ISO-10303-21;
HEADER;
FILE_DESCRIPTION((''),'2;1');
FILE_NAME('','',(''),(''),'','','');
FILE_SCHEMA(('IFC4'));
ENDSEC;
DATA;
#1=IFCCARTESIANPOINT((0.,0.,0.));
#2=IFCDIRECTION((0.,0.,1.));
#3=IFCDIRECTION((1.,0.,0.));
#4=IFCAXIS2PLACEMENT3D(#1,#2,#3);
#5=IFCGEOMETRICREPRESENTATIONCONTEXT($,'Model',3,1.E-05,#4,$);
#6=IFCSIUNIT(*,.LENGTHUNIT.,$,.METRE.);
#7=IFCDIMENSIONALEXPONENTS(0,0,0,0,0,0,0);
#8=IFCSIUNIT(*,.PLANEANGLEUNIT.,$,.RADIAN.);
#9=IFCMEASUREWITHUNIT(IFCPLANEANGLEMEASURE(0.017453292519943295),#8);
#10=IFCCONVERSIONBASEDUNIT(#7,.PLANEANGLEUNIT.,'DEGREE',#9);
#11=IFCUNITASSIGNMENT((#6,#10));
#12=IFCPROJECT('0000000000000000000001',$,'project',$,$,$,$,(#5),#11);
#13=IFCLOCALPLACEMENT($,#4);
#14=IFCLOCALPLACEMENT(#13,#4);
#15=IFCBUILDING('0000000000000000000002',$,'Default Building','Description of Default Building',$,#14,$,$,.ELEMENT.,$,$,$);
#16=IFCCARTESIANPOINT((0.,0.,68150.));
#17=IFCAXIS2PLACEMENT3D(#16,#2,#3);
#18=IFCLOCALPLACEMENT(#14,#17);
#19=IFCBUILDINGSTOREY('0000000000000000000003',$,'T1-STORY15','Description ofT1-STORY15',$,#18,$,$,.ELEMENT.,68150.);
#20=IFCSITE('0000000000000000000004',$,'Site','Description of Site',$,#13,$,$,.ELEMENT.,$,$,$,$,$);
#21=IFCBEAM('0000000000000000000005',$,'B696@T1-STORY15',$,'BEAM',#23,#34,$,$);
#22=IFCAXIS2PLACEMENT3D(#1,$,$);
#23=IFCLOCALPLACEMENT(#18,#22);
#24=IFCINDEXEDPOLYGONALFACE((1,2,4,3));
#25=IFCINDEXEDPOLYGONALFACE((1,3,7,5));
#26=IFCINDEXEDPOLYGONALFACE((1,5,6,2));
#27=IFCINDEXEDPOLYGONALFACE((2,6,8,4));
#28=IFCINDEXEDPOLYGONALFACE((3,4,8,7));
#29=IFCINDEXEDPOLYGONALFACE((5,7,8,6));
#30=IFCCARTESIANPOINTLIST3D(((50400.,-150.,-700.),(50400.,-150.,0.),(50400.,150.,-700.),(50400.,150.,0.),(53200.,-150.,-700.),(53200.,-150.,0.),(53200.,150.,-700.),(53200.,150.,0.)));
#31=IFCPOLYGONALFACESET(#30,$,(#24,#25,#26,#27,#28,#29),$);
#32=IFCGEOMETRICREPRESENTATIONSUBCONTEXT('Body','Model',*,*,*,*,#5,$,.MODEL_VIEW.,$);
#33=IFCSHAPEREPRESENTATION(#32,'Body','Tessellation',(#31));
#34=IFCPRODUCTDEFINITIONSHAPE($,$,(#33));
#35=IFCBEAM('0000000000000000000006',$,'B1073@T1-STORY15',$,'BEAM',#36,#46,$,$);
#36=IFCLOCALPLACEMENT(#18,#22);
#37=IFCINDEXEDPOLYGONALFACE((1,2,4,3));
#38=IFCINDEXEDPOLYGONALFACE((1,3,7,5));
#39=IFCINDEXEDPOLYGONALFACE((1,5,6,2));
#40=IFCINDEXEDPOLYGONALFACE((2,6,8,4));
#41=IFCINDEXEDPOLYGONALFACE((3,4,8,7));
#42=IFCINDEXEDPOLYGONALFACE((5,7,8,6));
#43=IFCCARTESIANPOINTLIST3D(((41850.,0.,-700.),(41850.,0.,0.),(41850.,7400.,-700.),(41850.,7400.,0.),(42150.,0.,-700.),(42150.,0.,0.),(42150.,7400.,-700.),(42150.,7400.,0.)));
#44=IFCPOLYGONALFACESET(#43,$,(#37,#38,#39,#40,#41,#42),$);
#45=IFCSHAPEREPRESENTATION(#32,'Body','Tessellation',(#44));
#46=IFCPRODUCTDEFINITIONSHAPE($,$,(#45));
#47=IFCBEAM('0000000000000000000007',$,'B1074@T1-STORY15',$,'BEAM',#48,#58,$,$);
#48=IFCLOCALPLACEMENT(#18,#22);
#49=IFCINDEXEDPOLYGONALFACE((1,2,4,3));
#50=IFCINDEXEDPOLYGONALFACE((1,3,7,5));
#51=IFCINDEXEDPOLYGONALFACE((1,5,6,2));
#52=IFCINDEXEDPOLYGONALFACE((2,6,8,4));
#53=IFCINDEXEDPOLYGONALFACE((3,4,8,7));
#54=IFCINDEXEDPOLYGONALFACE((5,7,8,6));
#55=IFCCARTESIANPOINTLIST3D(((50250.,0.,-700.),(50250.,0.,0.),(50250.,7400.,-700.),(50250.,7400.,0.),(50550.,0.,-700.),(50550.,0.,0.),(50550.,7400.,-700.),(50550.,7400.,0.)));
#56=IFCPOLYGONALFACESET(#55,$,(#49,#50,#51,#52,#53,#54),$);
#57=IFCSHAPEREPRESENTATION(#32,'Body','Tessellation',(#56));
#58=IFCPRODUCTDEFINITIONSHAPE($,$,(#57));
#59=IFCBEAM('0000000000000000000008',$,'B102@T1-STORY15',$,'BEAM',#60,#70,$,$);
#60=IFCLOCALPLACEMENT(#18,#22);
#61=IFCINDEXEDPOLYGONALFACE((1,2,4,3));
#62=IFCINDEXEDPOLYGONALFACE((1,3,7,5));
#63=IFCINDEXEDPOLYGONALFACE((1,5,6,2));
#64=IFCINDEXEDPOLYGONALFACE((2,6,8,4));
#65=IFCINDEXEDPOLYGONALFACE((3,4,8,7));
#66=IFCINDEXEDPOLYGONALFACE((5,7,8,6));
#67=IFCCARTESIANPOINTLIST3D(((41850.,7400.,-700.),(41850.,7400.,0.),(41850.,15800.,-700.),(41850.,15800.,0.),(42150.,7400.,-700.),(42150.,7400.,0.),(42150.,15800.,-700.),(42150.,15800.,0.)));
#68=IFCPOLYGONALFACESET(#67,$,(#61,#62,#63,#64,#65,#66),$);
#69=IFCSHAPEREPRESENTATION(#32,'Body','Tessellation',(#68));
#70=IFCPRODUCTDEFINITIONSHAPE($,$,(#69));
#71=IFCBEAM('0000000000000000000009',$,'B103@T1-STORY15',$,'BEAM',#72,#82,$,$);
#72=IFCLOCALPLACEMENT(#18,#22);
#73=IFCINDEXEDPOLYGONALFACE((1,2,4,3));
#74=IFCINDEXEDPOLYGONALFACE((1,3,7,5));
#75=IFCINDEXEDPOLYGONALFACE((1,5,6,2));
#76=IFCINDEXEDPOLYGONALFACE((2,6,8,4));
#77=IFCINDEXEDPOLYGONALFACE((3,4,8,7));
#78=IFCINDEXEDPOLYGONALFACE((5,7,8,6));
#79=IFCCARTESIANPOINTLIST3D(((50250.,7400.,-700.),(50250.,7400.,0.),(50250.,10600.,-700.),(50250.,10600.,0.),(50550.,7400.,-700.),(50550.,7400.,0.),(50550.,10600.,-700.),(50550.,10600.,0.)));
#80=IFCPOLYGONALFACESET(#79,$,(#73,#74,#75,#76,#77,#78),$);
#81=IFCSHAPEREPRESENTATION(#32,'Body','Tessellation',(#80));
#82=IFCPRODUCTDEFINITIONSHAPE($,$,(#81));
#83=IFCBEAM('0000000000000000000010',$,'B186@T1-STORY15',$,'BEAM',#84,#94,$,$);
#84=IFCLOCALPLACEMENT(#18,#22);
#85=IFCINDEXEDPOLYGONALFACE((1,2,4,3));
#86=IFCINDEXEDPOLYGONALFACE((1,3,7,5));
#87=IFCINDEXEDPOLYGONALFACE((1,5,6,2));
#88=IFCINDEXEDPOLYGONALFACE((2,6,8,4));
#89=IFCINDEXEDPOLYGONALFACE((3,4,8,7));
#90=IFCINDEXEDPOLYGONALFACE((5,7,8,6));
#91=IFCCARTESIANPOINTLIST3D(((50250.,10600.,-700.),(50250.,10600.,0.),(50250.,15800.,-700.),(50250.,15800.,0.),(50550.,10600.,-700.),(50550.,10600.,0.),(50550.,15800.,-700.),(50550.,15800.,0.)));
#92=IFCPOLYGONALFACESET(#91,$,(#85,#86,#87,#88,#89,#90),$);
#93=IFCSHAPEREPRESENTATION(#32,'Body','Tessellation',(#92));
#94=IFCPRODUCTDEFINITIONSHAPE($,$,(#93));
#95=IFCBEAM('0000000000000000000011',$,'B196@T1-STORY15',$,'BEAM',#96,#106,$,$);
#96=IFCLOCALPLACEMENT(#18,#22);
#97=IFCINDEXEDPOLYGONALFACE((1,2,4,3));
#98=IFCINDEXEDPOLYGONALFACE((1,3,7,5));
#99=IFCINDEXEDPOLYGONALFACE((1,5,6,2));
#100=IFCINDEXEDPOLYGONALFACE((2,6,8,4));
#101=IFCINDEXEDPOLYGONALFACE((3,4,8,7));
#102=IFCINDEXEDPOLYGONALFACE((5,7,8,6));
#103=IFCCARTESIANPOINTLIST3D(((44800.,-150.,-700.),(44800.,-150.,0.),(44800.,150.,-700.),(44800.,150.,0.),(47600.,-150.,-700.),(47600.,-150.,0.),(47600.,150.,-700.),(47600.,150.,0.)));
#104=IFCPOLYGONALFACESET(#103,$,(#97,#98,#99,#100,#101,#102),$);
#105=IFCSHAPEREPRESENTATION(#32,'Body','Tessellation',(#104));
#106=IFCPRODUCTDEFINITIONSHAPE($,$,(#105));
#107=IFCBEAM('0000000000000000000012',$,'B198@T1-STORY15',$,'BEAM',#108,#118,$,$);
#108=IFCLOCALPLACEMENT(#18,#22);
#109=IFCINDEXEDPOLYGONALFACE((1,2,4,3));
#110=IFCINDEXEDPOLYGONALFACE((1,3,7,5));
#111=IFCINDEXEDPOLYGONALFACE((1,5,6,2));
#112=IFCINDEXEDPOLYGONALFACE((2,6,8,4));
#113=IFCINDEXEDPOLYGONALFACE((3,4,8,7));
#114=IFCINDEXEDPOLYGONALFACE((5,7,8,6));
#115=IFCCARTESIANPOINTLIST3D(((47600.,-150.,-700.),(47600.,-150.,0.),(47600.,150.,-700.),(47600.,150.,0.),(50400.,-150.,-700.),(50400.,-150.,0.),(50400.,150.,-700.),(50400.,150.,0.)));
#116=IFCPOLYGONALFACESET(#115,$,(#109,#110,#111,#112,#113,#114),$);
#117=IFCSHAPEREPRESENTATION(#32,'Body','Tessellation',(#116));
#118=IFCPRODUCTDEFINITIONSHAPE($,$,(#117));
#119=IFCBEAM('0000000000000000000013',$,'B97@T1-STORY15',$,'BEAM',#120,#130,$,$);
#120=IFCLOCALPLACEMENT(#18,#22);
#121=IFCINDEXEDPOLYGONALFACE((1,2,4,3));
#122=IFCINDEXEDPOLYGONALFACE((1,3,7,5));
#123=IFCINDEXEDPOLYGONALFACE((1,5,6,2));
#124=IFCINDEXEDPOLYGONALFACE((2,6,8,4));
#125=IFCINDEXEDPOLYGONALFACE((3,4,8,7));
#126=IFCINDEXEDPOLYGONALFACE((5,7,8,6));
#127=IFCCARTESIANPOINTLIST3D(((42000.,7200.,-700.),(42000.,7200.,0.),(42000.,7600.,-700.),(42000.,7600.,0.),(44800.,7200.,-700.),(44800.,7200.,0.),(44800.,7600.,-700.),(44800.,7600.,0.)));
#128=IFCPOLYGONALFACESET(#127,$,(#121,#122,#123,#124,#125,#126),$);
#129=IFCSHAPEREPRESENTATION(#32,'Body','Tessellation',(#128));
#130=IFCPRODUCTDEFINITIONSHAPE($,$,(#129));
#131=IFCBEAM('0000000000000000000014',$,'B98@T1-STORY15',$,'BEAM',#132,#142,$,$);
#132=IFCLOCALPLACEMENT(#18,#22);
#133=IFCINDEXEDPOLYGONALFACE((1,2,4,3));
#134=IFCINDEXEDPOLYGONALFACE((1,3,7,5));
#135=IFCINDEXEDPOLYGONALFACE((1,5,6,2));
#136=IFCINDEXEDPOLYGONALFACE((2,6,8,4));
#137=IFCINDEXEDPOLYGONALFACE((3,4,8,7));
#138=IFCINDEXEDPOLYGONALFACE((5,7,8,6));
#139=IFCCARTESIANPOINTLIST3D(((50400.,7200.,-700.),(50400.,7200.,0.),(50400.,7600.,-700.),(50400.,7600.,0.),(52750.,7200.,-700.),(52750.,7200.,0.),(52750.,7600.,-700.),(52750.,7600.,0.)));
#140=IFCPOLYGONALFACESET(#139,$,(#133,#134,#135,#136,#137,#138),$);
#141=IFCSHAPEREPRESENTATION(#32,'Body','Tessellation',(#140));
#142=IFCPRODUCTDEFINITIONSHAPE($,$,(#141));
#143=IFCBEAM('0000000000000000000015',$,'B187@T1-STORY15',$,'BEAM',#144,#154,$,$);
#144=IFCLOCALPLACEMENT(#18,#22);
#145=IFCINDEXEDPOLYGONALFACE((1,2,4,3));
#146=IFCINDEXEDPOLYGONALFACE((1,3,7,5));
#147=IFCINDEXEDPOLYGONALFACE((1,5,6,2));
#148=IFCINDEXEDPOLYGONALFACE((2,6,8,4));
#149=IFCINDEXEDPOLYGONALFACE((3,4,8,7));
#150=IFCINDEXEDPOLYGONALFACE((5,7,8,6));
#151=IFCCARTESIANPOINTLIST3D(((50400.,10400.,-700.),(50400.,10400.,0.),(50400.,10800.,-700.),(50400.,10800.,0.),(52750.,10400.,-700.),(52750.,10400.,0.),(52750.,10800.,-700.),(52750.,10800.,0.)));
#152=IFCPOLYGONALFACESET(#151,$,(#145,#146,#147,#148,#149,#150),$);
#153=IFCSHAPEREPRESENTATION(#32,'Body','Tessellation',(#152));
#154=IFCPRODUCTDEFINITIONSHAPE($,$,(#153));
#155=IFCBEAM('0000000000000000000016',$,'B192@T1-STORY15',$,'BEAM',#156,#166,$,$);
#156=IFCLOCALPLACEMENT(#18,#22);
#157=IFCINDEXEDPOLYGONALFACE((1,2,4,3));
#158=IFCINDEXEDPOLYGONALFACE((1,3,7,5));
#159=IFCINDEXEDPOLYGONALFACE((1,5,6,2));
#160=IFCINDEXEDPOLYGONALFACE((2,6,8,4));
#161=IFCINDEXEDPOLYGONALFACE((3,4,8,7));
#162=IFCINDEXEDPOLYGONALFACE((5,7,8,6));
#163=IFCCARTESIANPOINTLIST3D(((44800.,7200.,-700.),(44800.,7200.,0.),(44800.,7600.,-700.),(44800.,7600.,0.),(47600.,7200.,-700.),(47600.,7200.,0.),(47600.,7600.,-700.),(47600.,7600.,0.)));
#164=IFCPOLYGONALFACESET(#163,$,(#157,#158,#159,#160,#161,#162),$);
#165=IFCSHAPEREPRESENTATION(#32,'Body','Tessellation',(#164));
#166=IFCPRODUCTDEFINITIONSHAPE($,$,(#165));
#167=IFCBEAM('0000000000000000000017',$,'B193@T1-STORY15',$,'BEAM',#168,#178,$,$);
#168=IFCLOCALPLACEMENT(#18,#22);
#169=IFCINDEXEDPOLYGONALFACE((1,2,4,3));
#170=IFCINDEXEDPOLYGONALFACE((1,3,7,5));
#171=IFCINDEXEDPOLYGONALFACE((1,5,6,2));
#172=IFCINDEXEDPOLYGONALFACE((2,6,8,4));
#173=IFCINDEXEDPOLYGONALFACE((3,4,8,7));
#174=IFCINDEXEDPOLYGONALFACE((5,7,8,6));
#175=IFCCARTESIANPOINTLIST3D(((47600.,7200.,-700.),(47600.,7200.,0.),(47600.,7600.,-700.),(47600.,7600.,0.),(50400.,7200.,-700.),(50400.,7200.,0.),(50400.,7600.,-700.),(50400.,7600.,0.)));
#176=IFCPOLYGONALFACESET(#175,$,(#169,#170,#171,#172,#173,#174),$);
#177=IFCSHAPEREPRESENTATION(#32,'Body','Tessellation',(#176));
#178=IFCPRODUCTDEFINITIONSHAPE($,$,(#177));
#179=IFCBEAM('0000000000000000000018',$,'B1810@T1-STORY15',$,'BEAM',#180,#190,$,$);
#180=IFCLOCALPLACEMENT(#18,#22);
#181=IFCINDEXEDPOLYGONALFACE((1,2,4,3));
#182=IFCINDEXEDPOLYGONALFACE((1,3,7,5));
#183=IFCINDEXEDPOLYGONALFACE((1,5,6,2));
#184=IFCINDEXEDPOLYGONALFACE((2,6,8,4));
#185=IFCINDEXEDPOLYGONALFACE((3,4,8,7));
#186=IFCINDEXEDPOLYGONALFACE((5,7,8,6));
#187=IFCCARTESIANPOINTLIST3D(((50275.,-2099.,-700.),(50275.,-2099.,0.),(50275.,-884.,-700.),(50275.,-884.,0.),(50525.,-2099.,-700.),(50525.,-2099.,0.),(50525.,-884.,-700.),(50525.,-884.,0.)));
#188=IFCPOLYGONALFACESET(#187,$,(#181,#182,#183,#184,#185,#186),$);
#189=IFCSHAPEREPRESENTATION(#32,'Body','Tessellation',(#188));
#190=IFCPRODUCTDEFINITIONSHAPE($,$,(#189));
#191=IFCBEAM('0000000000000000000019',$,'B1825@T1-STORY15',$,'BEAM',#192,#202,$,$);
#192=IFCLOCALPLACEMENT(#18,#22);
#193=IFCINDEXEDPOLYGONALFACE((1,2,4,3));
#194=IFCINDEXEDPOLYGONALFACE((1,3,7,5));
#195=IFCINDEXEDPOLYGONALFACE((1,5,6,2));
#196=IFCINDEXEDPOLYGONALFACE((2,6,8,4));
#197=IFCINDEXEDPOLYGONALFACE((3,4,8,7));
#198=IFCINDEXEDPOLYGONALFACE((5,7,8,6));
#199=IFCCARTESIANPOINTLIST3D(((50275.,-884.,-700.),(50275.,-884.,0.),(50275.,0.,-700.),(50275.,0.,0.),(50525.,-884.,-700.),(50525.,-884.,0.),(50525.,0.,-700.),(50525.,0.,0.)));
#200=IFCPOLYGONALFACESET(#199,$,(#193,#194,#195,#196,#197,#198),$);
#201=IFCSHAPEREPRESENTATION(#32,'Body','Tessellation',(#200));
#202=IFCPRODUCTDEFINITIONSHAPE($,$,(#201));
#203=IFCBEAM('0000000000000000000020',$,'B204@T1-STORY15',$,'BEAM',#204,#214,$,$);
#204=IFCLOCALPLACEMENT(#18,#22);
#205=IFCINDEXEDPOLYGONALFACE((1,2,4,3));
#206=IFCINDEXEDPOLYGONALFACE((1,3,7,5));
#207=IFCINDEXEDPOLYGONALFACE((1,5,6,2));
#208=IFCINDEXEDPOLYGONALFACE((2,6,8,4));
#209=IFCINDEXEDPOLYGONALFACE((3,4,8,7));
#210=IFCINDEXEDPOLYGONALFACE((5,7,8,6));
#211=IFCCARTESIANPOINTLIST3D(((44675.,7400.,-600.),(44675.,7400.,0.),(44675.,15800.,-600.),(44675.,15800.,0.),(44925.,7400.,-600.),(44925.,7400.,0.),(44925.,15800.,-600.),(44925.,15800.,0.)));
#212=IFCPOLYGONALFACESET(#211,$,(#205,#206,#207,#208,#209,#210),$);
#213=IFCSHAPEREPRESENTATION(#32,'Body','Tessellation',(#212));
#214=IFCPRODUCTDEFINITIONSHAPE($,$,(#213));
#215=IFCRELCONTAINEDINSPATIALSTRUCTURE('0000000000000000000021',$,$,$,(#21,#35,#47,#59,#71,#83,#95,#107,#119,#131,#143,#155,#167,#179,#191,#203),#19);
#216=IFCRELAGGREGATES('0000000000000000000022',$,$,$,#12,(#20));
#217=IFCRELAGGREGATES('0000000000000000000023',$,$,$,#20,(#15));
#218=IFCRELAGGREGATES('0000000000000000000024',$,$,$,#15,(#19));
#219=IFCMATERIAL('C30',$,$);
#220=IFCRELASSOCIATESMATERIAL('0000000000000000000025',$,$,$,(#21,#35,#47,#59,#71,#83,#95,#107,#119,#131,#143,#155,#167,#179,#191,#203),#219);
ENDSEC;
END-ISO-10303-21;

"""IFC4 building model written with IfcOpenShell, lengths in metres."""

from ifc_helpers import new_model, entity, si_unit, converted_unit, frame, origin_with_axes, place, context, subcontext, project, spatial, rectangle, extrude, material, element, save


model = new_model("IFC4")

# Units and contexts
model_context = context("Model", 3, precision=1e-05, world=origin_with_axes())
body_context = subcontext(model_context, "Body", "Model", "MODEL_VIEW")
ifc_project = project(units=[si_unit("LENGTHUNIT", "METRE"), converted_unit("PLANEANGLEUNIT", "DEGREE", entity("IfcPlaneAngleMeasure", 0.017453292519943295), si_unit("PLANEANGLEUNIT", "RADIAN"), dimensions=[0, 0, 0, 0, 0, 0, 0])], contexts=[model_context])

# Site, building, storey
site_placement = place(None, origin_with_axes())
site = spatial("IfcSite", under=ifc_project, at=site_placement, Name="Site", Description="Description of Site", CompositionType="ELEMENT")
building_placement = place(site_placement, origin_with_axes())
building = spatial("IfcBuilding", under=site, at=building_placement, Name="Default Building", Description="Description of Default Building", CompositionType="ELEMENT")
storey_placement = place(building_placement, frame((0.0, 0.0, 68150.0), z_axis=(0.0, 0.0, 1.0), x_axis=(1.0, 0.0, 0.0)))
storey = spatial("IfcBuildingStorey", under=building, at=storey_placement, Name="T1-STORY15", Description="Description ofT1-STORY15", CompositionType="ELEMENT", Elevation=68150.0)

# Beams
ifc_material_1 = material(Name="C30")
beam_1_placement = place(storey_placement, frame((50400.0, 0.0, -350.0), z_axis=(1.0, 0.0, 0.0), x_axis=(0.0, 1.0, 0.0)))
element("IfcBeam", 1, at=beam_1_placement, inside=storey, material=ifc_material_1, Name="B696@T1-STORY15", ObjectType="BEAM", context=body_context, shape_type="SweptSolid", body=[
    extrude(rectangle(XDim=300.0, YDim=700.0), origin_with_axes(), (0.0, 0.0, 1.0), 2800.0),
])
for number, where, z_axis, x_axis, name in (
    (2, (42000.0, 0.0, -350.0), (0.0, 1.0, 0.0), (-1.0, 0.0, 0.0), "B1073@T1-STORY15"),
    (3, (50400.0, 0.0, -350.0), (0.0, 1.0, 0.0), (-1.0, 0.0, 0.0), "B1074@T1-STORY15"),
):
    element("IfcBeam", number, at=place(storey_placement, frame(where, z_axis=z_axis, x_axis=x_axis)), inside=storey, material=ifc_material_1, Name=name, ObjectType="BEAM", context=body_context, shape_type="SweptSolid", body=[
        extrude(rectangle(XDim=300.0, YDim=700.0), origin_with_axes(), (0.0, 0.0, 1.0), 7400.0),
    ])
beam_2_placement = place(storey_placement, frame((42000.0, 7400.0, -350.0), z_axis=(0.0, 1.0, 0.0), x_axis=(-1.0, 0.0, 0.0)))
element("IfcBeam", 4, at=beam_2_placement, inside=storey, material=ifc_material_1, Name="B102@T1-STORY15", ObjectType="BEAM", context=body_context, shape_type="SweptSolid", body=[
    extrude(rectangle(XDim=300.0, YDim=700.0), origin_with_axes(), (0.0, 0.0, 1.0), 8400.0),
])
beam_3_placement = place(storey_placement, frame((50400.0, 7400.0, -350.0), z_axis=(0.0, 1.0, 0.0), x_axis=(-1.0, 0.0, 0.0)))
element("IfcBeam", 5, at=beam_3_placement, inside=storey, material=ifc_material_1, Name="B103@T1-STORY15", ObjectType="BEAM", context=body_context, shape_type="SweptSolid", body=[
    extrude(rectangle(XDim=300.0, YDim=700.0), origin_with_axes(), (0.0, 0.0, 1.0), 3200.0),
])
beam_4_placement = place(storey_placement, frame((50400.0, 10600.0, -350.0), z_axis=(0.0, 1.0, 0.0), x_axis=(-1.0, 0.0, 0.0)))
element("IfcBeam", 6, at=beam_4_placement, inside=storey, material=ifc_material_1, Name="B186@T1-STORY15", ObjectType="BEAM", context=body_context, shape_type="SweptSolid", body=[
    extrude(rectangle(XDim=300.0, YDim=700.0), origin_with_axes(), (0.0, 0.0, 1.0), 5200.0),
])
for number, where, z_axis, x_axis, name in (
    (7, (44800.0, 0.0, -350.0), (1.0, 0.0, 0.0), (0.0, 1.0, 0.0), "B196@T1-STORY15"),
    (8, (47600.0, 0.0, -350.0), (1.0, 0.0, 0.0), (0.0, 1.0, 0.0), "B198@T1-STORY15"),
):
    element("IfcBeam", number, at=place(storey_placement, frame(where, z_axis=z_axis, x_axis=x_axis)), inside=storey, material=ifc_material_1, Name=name, ObjectType="BEAM", context=body_context, shape_type="SweptSolid", body=[
        extrude(rectangle(XDim=300.0, YDim=700.0), origin_with_axes(), (0.0, 0.0, 1.0), 2800.0),
    ])
beam_5_placement = place(storey_placement, frame((42000.0, 7400.0, -350.0), z_axis=(1.0, 0.0, 0.0), x_axis=(0.0, 1.0, 0.0)))
element("IfcBeam", 9, at=beam_5_placement, inside=storey, material=ifc_material_1, Name="B97@T1-STORY15", ObjectType="BEAM", context=body_context, shape_type="SweptSolid", body=[
    extrude(rectangle(XDim=400.0, YDim=700.0), origin_with_axes(), (0.0, 0.0, 1.0), 2800.0),
])
for number, where, z_axis, x_axis, name in (
    (10, (50400.0, 7400.0, -350.0), (1.0, 0.0, 0.0), (0.0, 1.0, 0.0), "B98@T1-STORY15"),
    (11, (50400.0, 10600.0, -350.0), (1.0, 0.0, 0.0), (0.0, 1.0, 0.0), "B187@T1-STORY15"),
):
    element("IfcBeam", number, at=place(storey_placement, frame(where, z_axis=z_axis, x_axis=x_axis)), inside=storey, material=ifc_material_1, Name=name, ObjectType="BEAM", context=body_context, shape_type="SweptSolid", body=[
        extrude(rectangle(XDim=400.0, YDim=700.0), origin_with_axes(), (0.0, 0.0, 1.0), 2350.0),
    ])
for number, where, z_axis, x_axis, name in (
    (12, (44800.0, 7400.0, -350.0), (1.0, 0.0, 0.0), (0.0, 1.0, 0.0), "B192@T1-STORY15"),
    (13, (47600.0, 7400.0, -350.0), (1.0, 0.0, 0.0), (0.0, 1.0, 0.0), "B193@T1-STORY15"),
):
    element("IfcBeam", number, at=place(storey_placement, frame(where, z_axis=z_axis, x_axis=x_axis)), inside=storey, material=ifc_material_1, Name=name, ObjectType="BEAM", context=body_context, shape_type="SweptSolid", body=[
        extrude(rectangle(XDim=400.0, YDim=700.0), origin_with_axes(), (0.0, 0.0, 1.0), 2800.0),
    ])
beam_6_placement = place(storey_placement, frame((50400.0, -2099.0, -350.0), z_axis=(0.0, 1.0, 0.0), x_axis=(-1.0, 0.0, 0.0)))
element("IfcBeam", 14, at=beam_6_placement, inside=storey, material=ifc_material_1, Name="B1810@T1-STORY15", ObjectType="BEAM", context=body_context, shape_type="SweptSolid", body=[
    extrude(rectangle(XDim=250.0, YDim=700.0), origin_with_axes(), (0.0, 0.0, 1.0), 1215.0),
])
beam_7_placement = place(storey_placement, frame((50400.0, -884.0, -350.0), z_axis=(0.0, 1.0, 0.0), x_axis=(-1.0, 0.0, 0.0)))
element("IfcBeam", 15, at=beam_7_placement, inside=storey, material=ifc_material_1, Name="B1825@T1-STORY15", ObjectType="BEAM", context=body_context, shape_type="SweptSolid", body=[
    extrude(rectangle(XDim=250.0, YDim=700.0), origin_with_axes(), (0.0, 0.0, 1.0), 884.0),
])
for number, where, z_axis, x_axis, name in (
    (16, (44800.0, 7400.0, -300.0), (0.0, 1.0, 0.0), (-1.0, 0.0, 0.0), "B204@T1-STORY15"),
):
    element("IfcBeam", number, at=place(storey_placement, frame(where, z_axis=z_axis, x_axis=x_axis)), inside=storey, material=ifc_material_1, Name=name, ObjectType="BEAM", context=body_context, shape_type="SweptSolid", body=[
        extrude(rectangle(XDim=250.0, YDim=600.0), origin_with_axes(), (0.0, 0.0, 1.0), 8400.0),
    ])

save(model, "model.ifc")
